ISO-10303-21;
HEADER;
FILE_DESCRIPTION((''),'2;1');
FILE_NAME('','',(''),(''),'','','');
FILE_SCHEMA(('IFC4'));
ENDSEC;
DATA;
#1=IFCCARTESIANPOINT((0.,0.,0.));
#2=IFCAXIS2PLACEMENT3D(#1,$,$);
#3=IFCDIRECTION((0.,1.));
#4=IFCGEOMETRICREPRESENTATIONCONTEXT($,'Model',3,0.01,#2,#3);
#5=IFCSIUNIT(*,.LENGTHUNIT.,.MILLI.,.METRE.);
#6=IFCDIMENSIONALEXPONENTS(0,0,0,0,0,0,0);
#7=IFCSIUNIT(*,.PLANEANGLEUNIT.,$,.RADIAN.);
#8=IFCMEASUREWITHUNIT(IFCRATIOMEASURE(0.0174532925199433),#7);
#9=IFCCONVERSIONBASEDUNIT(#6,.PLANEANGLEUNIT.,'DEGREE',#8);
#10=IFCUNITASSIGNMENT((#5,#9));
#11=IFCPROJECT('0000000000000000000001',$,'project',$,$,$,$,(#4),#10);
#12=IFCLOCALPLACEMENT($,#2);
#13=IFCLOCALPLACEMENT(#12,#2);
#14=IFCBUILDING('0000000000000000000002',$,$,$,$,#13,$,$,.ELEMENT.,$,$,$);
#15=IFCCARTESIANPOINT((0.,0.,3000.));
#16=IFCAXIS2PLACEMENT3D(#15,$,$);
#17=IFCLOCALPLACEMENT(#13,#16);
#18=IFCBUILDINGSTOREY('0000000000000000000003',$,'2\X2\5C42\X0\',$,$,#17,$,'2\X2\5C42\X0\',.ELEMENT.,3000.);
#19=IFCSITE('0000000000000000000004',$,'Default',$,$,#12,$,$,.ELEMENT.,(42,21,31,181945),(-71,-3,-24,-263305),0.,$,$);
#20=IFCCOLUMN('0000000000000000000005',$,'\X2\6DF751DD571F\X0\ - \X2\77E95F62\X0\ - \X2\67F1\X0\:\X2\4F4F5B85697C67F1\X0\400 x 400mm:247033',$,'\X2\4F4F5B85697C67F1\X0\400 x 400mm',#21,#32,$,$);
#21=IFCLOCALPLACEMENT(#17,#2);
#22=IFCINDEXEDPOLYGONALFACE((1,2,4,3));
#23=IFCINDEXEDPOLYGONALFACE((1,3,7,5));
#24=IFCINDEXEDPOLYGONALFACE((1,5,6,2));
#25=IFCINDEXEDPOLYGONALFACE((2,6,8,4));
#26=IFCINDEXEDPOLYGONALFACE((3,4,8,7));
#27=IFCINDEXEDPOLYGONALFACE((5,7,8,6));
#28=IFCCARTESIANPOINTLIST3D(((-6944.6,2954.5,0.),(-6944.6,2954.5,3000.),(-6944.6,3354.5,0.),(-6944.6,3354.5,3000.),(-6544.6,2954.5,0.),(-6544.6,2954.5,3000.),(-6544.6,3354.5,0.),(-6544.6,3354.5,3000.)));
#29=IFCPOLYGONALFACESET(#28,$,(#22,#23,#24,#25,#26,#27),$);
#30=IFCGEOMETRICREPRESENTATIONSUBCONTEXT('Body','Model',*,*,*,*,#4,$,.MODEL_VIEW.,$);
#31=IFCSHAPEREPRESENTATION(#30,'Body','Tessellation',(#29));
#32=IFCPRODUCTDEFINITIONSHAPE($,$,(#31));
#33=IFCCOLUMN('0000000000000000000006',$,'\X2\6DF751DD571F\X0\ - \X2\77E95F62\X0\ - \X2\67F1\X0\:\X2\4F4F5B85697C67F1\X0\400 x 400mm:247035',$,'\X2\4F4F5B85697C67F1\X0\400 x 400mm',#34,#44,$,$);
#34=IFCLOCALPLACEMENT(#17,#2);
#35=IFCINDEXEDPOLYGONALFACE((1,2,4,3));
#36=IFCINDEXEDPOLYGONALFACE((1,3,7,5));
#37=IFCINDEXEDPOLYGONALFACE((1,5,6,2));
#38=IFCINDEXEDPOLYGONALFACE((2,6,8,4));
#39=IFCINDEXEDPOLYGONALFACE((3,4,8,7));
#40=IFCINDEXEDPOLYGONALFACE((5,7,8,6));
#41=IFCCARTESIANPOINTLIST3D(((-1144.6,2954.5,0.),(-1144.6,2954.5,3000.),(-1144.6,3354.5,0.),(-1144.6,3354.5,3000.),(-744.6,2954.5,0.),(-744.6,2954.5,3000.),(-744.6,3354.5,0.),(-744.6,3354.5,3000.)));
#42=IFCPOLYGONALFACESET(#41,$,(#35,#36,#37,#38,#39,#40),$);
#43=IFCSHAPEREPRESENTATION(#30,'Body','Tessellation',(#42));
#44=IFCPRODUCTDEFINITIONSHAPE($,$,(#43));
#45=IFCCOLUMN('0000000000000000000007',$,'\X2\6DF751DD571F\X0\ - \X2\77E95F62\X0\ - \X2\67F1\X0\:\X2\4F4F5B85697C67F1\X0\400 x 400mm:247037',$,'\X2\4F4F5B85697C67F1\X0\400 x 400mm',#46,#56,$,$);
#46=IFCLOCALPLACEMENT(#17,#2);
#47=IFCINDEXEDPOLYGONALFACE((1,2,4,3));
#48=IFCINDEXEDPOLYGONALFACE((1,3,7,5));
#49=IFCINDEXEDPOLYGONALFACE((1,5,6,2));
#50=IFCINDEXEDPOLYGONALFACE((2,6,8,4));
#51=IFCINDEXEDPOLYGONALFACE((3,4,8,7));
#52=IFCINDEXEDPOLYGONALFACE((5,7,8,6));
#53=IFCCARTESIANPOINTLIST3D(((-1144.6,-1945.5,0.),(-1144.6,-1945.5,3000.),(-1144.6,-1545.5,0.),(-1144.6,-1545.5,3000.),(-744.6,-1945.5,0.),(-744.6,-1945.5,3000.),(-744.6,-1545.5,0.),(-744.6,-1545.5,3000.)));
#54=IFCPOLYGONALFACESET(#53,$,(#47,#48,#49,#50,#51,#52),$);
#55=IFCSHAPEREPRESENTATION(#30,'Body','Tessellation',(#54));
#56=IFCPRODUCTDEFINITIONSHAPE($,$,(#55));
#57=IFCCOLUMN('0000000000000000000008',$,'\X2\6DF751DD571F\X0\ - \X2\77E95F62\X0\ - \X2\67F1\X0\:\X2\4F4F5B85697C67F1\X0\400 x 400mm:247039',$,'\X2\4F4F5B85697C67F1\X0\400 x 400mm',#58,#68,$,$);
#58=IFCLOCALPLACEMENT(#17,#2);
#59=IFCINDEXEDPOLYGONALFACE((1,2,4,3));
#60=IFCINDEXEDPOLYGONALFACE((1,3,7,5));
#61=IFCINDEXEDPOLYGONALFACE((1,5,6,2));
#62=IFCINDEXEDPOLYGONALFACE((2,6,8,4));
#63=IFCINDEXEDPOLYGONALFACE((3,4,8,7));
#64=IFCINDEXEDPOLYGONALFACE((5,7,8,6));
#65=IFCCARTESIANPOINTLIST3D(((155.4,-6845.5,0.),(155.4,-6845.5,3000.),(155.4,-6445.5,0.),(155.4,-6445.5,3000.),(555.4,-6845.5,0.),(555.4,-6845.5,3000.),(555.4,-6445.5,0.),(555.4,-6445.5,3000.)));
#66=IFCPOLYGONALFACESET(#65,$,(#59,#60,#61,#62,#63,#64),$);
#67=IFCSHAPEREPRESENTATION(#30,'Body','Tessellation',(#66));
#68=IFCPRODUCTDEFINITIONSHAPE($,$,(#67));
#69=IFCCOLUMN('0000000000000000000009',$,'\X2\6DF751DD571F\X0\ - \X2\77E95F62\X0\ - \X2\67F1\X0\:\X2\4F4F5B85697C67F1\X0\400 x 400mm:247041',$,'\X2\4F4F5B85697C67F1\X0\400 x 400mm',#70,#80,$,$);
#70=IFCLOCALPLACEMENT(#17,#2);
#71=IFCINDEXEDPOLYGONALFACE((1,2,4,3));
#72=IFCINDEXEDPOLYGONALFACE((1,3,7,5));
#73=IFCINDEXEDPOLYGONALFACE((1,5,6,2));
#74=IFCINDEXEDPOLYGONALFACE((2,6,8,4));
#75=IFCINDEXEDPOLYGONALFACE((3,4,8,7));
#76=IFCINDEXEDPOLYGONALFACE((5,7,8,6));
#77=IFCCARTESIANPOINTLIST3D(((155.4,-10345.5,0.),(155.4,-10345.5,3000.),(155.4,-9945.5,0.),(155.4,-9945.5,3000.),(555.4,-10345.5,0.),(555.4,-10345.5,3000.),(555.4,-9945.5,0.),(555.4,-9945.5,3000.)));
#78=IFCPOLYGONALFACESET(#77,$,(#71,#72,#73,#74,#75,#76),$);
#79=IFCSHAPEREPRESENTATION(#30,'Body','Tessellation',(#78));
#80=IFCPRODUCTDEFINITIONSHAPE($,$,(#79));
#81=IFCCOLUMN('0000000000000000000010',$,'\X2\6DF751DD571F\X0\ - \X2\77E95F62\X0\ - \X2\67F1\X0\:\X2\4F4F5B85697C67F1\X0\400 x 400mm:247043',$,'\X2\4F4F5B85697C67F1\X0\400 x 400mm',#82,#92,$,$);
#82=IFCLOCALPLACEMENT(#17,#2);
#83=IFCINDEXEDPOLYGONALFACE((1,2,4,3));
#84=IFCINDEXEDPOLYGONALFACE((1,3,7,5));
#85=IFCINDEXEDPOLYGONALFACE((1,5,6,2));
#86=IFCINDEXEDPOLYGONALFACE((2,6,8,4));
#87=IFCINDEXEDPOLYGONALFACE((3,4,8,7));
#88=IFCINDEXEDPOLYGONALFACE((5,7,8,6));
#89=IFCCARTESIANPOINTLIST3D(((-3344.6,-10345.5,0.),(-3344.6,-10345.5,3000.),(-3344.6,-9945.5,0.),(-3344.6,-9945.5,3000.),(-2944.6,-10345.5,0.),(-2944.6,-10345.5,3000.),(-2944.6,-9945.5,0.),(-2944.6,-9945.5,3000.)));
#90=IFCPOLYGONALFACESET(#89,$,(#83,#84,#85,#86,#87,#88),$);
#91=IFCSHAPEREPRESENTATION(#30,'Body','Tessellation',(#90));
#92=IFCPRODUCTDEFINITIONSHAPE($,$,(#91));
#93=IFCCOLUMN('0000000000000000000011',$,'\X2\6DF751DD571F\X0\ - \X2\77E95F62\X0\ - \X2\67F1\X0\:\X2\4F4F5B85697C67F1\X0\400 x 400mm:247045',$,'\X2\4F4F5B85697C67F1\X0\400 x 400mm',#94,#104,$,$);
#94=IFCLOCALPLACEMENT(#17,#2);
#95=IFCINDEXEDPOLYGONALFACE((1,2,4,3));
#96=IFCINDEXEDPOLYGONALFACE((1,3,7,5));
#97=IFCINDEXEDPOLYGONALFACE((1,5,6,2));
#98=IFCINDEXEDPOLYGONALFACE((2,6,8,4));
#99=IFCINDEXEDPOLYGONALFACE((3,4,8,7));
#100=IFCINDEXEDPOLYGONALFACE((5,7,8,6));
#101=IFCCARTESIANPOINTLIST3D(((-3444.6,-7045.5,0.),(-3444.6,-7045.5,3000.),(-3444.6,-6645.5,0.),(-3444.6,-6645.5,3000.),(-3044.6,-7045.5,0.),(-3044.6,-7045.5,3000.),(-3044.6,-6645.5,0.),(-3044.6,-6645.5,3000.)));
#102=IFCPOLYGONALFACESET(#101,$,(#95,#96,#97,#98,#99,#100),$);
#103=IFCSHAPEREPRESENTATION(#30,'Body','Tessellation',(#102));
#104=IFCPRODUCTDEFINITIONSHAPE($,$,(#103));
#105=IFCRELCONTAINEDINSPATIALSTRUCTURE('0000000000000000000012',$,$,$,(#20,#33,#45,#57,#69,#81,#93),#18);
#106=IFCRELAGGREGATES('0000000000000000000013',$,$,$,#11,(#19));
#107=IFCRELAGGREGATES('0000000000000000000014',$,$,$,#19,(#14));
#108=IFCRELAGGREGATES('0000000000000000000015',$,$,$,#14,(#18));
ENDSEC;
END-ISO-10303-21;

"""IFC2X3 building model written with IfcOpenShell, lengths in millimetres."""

from ifc_helpers import new_model, entity, si_unit, converted_unit, direction, frame, frame_2d, origin, origin_2d_with_axis, place, context, subcontext, project, spatial, rectangle, extrude, source, transform, mapped, element, save


model = new_model("IFC2X3")

# Units and contexts
model_context = context("Model", 3, precision=0.01, world=origin(), true_north=direction((0.0, 1.0)))
body_context = subcontext(model_context, "Body", "Model", "MODEL_VIEW")
ifc_project = project(units=[si_unit("LENGTHUNIT", "METRE", prefix="MILLI"), converted_unit("PLANEANGLEUNIT", "DEGREE", entity("IfcRatioMeasure", 0.0174532925199433), si_unit("PLANEANGLEUNIT", "RADIAN"), dimensions=[0, 0, 0, 0, 0, 0, 0])], contexts=[model_context])

# Site, building, storey
site_placement = place(None, origin())
site = spatial("IfcSite", under=ifc_project, at=site_placement, Name="Default", CompositionType="ELEMENT", RefLatitude=(42, 21, 31, 181945), RefLongitude=(-71, -3, -24, -263305), RefElevation=0.0)
building_placement = place(site_placement, origin())
building = spatial("IfcBuilding", under=site, at=building_placement, CompositionType="ELEMENT")
storey_placement = place(building_placement, frame((0.0, 0.0, 3000.0)))
storey = spatial("IfcBuildingStorey", under=building, at=storey_placement, Name="2层", LongName="2层", CompositionType="ELEMENT", Elevation=3000.0)

# Columns
shared_shape_1 = source(origin(), body_context, "Body", "SweptSolid", [
    extrude(rectangle(XDim=400.0, YDim=400.0, at=origin_2d_with_axis()), frame((-6744.6, 3154.5, 3000.0), z_axis=(0.0, 0.0, 1.0), x_axis=(0.0, -1.0, 0.0)), (0.0, 0.0, 1.0), 3000.0),
])
column_1_placement = place(storey_placement, frame((0.0, 0.0, -3000.0)))
element("IfcColumn", 1, at=column_1_placement, inside=storey, Name="混凝土 - 矩形 - 柱:住宅楼柱400 x 400mm:247033", ObjectType="住宅楼柱400 x 400mm", context=body_context, shape_type="MappedRepresentation", body=[
    mapped(shared_shape_1, transform((0.0, 0.0, 0.0), scale=1.0)),
])
shared_shape_2 = source(origin(), body_context, "Body", "SweptSolid", [
    extrude(rectangle(XDim=400.0, YDim=400.0, at=origin_2d_with_axis()), frame((-944.6, 3154.5, 3000.0), z_axis=(0.0, 0.0, 1.0), x_axis=(0.0, -1.0, 0.0)), (0.0, 0.0, 1.0), 3000.0),
])
column_2_placement = place(storey_placement, frame((0.0, 0.0, -3000.0)))
element("IfcColumn", 2, at=column_2_placement, inside=storey, Name="混凝土 - 矩形 - 柱:住宅楼柱400 x 400mm:247035", ObjectType="住宅楼柱400 x 400mm", context=body_context, shape_type="MappedRepresentation", body=[
    mapped(shared_shape_2, transform((0.0, 0.0, 0.0), scale=1.0)),
])
shared_shape_3 = source(origin(), body_context, "Body", "SweptSolid", [
    extrude(rectangle(XDim=400.0, YDim=400.0, at=origin_2d_with_axis()), frame((-944.6, -1745.5, 3000.0), z_axis=(0.0, 0.0, 1.0), x_axis=(0.0, -1.0, 0.0)), (0.0, 0.0, 1.0), 3000.0),
])
column_3_placement = place(storey_placement, frame((0.0, 0.0, -3000.0)))
element("IfcColumn", 3, at=column_3_placement, inside=storey, Name="混凝土 - 矩形 - 柱:住宅楼柱400 x 400mm:247037", ObjectType="住宅楼柱400 x 400mm", context=body_context, shape_type="MappedRepresentation", body=[
    mapped(shared_shape_3, transform((0.0, 0.0, 0.0), scale=1.0)),
])
shared_shape_4 = source(origin(), body_context, "Body", "SweptSolid", [
    extrude(rectangle(XDim=400.0, YDim=400.0, at=frame_2d((0.0, 0.0), x_axis=(1.0, 0.0))), frame((355.4, -6645.5, 3000.0), z_axis=(0.0, 0.0, 1.0), x_axis=(0.0, -1.0, 0.0)), (0.0, 0.0, 1.0), 3000.0),
])
column_4_placement = place(storey_placement, frame((0.0, 0.0, -3000.0)))
element("IfcColumn", 4, at=column_4_placement, inside=storey, Name="混凝土 - 矩形 - 柱:住宅楼柱400 x 400mm:247039", ObjectType="住宅楼柱400 x 400mm", context=body_context, shape_type="MappedRepresentation", body=[
    mapped(shared_shape_4, transform((0.0, 0.0, 0.0), scale=1.0)),
])
shared_shape_5 = source(origin(), body_context, "Body", "SweptSolid", [
    extrude(rectangle(XDim=400.0, YDim=400.0, at=frame_2d((0.0, 0.0), x_axis=(1.0, 0.0))), frame((355.4, -10145.5, 3000.0), z_axis=(0.0, 0.0, 1.0), x_axis=(0.0, -1.0, 0.0)), (0.0, 0.0, 1.0), 3000.0),
])
column_5_placement = place(storey_placement, frame((0.0, 0.0, -3000.0)))
element("IfcColumn", 5, at=column_5_placement, inside=storey, Name="混凝土 - 矩形 - 柱:住宅楼柱400 x 400mm:247041", ObjectType="住宅楼柱400 x 400mm", context=body_context, shape_type="MappedRepresentation", body=[
    mapped(shared_shape_5, transform((0.0, 0.0, 0.0), scale=1.0)),
])
shared_shape_6 = source(origin(), body_context, "Body", "SweptSolid", [
    extrude(rectangle(XDim=400.0, YDim=400.0, at=origin_2d_with_axis()), frame((-3144.6, -10145.5, 3000.0), z_axis=(0.0, 0.0, 1.0), x_axis=(0.0, -1.0, 0.0)), (0.0, 0.0, 1.0), 3000.0),
])
column_6_placement = place(storey_placement, frame((0.0, 0.0, -3000.0)))
element("IfcColumn", 6, at=column_6_placement, inside=storey, Name="混凝土 - 矩形 - 柱:住宅楼柱400 x 400mm:247043", ObjectType="住宅楼柱400 x 400mm", context=body_context, shape_type="MappedRepresentation", body=[
    mapped(shared_shape_6, transform((0.0, 0.0, 0.0), scale=1.0)),
])
shared_shape_7 = source(origin(), body_context, "Body", "SweptSolid", [
    extrude(rectangle(XDim=400.0, YDim=400.0, at=origin_2d_with_axis()), frame((-3244.6, -6845.5, 3000.0), z_axis=(0.0, 0.0, 1.0), x_axis=(0.0, -1.0, 0.0)), (0.0, 0.0, 1.0), 3000.0),
])
column_7_placement = place(storey_placement, frame((0.0, 0.0, -3000.0)))
element("IfcColumn", 7, at=column_7_placement, inside=storey, Name="混凝土 - 矩形 - 柱:住宅楼柱400 x 400mm:247045", ObjectType="住宅楼柱400 x 400mm", context=body_context, shape_type="MappedRepresentation", body=[
    mapped(shared_shape_7, transform((0.0, 0.0, 0.0), scale=1.0)),
])

save(model, "model.ifc")
